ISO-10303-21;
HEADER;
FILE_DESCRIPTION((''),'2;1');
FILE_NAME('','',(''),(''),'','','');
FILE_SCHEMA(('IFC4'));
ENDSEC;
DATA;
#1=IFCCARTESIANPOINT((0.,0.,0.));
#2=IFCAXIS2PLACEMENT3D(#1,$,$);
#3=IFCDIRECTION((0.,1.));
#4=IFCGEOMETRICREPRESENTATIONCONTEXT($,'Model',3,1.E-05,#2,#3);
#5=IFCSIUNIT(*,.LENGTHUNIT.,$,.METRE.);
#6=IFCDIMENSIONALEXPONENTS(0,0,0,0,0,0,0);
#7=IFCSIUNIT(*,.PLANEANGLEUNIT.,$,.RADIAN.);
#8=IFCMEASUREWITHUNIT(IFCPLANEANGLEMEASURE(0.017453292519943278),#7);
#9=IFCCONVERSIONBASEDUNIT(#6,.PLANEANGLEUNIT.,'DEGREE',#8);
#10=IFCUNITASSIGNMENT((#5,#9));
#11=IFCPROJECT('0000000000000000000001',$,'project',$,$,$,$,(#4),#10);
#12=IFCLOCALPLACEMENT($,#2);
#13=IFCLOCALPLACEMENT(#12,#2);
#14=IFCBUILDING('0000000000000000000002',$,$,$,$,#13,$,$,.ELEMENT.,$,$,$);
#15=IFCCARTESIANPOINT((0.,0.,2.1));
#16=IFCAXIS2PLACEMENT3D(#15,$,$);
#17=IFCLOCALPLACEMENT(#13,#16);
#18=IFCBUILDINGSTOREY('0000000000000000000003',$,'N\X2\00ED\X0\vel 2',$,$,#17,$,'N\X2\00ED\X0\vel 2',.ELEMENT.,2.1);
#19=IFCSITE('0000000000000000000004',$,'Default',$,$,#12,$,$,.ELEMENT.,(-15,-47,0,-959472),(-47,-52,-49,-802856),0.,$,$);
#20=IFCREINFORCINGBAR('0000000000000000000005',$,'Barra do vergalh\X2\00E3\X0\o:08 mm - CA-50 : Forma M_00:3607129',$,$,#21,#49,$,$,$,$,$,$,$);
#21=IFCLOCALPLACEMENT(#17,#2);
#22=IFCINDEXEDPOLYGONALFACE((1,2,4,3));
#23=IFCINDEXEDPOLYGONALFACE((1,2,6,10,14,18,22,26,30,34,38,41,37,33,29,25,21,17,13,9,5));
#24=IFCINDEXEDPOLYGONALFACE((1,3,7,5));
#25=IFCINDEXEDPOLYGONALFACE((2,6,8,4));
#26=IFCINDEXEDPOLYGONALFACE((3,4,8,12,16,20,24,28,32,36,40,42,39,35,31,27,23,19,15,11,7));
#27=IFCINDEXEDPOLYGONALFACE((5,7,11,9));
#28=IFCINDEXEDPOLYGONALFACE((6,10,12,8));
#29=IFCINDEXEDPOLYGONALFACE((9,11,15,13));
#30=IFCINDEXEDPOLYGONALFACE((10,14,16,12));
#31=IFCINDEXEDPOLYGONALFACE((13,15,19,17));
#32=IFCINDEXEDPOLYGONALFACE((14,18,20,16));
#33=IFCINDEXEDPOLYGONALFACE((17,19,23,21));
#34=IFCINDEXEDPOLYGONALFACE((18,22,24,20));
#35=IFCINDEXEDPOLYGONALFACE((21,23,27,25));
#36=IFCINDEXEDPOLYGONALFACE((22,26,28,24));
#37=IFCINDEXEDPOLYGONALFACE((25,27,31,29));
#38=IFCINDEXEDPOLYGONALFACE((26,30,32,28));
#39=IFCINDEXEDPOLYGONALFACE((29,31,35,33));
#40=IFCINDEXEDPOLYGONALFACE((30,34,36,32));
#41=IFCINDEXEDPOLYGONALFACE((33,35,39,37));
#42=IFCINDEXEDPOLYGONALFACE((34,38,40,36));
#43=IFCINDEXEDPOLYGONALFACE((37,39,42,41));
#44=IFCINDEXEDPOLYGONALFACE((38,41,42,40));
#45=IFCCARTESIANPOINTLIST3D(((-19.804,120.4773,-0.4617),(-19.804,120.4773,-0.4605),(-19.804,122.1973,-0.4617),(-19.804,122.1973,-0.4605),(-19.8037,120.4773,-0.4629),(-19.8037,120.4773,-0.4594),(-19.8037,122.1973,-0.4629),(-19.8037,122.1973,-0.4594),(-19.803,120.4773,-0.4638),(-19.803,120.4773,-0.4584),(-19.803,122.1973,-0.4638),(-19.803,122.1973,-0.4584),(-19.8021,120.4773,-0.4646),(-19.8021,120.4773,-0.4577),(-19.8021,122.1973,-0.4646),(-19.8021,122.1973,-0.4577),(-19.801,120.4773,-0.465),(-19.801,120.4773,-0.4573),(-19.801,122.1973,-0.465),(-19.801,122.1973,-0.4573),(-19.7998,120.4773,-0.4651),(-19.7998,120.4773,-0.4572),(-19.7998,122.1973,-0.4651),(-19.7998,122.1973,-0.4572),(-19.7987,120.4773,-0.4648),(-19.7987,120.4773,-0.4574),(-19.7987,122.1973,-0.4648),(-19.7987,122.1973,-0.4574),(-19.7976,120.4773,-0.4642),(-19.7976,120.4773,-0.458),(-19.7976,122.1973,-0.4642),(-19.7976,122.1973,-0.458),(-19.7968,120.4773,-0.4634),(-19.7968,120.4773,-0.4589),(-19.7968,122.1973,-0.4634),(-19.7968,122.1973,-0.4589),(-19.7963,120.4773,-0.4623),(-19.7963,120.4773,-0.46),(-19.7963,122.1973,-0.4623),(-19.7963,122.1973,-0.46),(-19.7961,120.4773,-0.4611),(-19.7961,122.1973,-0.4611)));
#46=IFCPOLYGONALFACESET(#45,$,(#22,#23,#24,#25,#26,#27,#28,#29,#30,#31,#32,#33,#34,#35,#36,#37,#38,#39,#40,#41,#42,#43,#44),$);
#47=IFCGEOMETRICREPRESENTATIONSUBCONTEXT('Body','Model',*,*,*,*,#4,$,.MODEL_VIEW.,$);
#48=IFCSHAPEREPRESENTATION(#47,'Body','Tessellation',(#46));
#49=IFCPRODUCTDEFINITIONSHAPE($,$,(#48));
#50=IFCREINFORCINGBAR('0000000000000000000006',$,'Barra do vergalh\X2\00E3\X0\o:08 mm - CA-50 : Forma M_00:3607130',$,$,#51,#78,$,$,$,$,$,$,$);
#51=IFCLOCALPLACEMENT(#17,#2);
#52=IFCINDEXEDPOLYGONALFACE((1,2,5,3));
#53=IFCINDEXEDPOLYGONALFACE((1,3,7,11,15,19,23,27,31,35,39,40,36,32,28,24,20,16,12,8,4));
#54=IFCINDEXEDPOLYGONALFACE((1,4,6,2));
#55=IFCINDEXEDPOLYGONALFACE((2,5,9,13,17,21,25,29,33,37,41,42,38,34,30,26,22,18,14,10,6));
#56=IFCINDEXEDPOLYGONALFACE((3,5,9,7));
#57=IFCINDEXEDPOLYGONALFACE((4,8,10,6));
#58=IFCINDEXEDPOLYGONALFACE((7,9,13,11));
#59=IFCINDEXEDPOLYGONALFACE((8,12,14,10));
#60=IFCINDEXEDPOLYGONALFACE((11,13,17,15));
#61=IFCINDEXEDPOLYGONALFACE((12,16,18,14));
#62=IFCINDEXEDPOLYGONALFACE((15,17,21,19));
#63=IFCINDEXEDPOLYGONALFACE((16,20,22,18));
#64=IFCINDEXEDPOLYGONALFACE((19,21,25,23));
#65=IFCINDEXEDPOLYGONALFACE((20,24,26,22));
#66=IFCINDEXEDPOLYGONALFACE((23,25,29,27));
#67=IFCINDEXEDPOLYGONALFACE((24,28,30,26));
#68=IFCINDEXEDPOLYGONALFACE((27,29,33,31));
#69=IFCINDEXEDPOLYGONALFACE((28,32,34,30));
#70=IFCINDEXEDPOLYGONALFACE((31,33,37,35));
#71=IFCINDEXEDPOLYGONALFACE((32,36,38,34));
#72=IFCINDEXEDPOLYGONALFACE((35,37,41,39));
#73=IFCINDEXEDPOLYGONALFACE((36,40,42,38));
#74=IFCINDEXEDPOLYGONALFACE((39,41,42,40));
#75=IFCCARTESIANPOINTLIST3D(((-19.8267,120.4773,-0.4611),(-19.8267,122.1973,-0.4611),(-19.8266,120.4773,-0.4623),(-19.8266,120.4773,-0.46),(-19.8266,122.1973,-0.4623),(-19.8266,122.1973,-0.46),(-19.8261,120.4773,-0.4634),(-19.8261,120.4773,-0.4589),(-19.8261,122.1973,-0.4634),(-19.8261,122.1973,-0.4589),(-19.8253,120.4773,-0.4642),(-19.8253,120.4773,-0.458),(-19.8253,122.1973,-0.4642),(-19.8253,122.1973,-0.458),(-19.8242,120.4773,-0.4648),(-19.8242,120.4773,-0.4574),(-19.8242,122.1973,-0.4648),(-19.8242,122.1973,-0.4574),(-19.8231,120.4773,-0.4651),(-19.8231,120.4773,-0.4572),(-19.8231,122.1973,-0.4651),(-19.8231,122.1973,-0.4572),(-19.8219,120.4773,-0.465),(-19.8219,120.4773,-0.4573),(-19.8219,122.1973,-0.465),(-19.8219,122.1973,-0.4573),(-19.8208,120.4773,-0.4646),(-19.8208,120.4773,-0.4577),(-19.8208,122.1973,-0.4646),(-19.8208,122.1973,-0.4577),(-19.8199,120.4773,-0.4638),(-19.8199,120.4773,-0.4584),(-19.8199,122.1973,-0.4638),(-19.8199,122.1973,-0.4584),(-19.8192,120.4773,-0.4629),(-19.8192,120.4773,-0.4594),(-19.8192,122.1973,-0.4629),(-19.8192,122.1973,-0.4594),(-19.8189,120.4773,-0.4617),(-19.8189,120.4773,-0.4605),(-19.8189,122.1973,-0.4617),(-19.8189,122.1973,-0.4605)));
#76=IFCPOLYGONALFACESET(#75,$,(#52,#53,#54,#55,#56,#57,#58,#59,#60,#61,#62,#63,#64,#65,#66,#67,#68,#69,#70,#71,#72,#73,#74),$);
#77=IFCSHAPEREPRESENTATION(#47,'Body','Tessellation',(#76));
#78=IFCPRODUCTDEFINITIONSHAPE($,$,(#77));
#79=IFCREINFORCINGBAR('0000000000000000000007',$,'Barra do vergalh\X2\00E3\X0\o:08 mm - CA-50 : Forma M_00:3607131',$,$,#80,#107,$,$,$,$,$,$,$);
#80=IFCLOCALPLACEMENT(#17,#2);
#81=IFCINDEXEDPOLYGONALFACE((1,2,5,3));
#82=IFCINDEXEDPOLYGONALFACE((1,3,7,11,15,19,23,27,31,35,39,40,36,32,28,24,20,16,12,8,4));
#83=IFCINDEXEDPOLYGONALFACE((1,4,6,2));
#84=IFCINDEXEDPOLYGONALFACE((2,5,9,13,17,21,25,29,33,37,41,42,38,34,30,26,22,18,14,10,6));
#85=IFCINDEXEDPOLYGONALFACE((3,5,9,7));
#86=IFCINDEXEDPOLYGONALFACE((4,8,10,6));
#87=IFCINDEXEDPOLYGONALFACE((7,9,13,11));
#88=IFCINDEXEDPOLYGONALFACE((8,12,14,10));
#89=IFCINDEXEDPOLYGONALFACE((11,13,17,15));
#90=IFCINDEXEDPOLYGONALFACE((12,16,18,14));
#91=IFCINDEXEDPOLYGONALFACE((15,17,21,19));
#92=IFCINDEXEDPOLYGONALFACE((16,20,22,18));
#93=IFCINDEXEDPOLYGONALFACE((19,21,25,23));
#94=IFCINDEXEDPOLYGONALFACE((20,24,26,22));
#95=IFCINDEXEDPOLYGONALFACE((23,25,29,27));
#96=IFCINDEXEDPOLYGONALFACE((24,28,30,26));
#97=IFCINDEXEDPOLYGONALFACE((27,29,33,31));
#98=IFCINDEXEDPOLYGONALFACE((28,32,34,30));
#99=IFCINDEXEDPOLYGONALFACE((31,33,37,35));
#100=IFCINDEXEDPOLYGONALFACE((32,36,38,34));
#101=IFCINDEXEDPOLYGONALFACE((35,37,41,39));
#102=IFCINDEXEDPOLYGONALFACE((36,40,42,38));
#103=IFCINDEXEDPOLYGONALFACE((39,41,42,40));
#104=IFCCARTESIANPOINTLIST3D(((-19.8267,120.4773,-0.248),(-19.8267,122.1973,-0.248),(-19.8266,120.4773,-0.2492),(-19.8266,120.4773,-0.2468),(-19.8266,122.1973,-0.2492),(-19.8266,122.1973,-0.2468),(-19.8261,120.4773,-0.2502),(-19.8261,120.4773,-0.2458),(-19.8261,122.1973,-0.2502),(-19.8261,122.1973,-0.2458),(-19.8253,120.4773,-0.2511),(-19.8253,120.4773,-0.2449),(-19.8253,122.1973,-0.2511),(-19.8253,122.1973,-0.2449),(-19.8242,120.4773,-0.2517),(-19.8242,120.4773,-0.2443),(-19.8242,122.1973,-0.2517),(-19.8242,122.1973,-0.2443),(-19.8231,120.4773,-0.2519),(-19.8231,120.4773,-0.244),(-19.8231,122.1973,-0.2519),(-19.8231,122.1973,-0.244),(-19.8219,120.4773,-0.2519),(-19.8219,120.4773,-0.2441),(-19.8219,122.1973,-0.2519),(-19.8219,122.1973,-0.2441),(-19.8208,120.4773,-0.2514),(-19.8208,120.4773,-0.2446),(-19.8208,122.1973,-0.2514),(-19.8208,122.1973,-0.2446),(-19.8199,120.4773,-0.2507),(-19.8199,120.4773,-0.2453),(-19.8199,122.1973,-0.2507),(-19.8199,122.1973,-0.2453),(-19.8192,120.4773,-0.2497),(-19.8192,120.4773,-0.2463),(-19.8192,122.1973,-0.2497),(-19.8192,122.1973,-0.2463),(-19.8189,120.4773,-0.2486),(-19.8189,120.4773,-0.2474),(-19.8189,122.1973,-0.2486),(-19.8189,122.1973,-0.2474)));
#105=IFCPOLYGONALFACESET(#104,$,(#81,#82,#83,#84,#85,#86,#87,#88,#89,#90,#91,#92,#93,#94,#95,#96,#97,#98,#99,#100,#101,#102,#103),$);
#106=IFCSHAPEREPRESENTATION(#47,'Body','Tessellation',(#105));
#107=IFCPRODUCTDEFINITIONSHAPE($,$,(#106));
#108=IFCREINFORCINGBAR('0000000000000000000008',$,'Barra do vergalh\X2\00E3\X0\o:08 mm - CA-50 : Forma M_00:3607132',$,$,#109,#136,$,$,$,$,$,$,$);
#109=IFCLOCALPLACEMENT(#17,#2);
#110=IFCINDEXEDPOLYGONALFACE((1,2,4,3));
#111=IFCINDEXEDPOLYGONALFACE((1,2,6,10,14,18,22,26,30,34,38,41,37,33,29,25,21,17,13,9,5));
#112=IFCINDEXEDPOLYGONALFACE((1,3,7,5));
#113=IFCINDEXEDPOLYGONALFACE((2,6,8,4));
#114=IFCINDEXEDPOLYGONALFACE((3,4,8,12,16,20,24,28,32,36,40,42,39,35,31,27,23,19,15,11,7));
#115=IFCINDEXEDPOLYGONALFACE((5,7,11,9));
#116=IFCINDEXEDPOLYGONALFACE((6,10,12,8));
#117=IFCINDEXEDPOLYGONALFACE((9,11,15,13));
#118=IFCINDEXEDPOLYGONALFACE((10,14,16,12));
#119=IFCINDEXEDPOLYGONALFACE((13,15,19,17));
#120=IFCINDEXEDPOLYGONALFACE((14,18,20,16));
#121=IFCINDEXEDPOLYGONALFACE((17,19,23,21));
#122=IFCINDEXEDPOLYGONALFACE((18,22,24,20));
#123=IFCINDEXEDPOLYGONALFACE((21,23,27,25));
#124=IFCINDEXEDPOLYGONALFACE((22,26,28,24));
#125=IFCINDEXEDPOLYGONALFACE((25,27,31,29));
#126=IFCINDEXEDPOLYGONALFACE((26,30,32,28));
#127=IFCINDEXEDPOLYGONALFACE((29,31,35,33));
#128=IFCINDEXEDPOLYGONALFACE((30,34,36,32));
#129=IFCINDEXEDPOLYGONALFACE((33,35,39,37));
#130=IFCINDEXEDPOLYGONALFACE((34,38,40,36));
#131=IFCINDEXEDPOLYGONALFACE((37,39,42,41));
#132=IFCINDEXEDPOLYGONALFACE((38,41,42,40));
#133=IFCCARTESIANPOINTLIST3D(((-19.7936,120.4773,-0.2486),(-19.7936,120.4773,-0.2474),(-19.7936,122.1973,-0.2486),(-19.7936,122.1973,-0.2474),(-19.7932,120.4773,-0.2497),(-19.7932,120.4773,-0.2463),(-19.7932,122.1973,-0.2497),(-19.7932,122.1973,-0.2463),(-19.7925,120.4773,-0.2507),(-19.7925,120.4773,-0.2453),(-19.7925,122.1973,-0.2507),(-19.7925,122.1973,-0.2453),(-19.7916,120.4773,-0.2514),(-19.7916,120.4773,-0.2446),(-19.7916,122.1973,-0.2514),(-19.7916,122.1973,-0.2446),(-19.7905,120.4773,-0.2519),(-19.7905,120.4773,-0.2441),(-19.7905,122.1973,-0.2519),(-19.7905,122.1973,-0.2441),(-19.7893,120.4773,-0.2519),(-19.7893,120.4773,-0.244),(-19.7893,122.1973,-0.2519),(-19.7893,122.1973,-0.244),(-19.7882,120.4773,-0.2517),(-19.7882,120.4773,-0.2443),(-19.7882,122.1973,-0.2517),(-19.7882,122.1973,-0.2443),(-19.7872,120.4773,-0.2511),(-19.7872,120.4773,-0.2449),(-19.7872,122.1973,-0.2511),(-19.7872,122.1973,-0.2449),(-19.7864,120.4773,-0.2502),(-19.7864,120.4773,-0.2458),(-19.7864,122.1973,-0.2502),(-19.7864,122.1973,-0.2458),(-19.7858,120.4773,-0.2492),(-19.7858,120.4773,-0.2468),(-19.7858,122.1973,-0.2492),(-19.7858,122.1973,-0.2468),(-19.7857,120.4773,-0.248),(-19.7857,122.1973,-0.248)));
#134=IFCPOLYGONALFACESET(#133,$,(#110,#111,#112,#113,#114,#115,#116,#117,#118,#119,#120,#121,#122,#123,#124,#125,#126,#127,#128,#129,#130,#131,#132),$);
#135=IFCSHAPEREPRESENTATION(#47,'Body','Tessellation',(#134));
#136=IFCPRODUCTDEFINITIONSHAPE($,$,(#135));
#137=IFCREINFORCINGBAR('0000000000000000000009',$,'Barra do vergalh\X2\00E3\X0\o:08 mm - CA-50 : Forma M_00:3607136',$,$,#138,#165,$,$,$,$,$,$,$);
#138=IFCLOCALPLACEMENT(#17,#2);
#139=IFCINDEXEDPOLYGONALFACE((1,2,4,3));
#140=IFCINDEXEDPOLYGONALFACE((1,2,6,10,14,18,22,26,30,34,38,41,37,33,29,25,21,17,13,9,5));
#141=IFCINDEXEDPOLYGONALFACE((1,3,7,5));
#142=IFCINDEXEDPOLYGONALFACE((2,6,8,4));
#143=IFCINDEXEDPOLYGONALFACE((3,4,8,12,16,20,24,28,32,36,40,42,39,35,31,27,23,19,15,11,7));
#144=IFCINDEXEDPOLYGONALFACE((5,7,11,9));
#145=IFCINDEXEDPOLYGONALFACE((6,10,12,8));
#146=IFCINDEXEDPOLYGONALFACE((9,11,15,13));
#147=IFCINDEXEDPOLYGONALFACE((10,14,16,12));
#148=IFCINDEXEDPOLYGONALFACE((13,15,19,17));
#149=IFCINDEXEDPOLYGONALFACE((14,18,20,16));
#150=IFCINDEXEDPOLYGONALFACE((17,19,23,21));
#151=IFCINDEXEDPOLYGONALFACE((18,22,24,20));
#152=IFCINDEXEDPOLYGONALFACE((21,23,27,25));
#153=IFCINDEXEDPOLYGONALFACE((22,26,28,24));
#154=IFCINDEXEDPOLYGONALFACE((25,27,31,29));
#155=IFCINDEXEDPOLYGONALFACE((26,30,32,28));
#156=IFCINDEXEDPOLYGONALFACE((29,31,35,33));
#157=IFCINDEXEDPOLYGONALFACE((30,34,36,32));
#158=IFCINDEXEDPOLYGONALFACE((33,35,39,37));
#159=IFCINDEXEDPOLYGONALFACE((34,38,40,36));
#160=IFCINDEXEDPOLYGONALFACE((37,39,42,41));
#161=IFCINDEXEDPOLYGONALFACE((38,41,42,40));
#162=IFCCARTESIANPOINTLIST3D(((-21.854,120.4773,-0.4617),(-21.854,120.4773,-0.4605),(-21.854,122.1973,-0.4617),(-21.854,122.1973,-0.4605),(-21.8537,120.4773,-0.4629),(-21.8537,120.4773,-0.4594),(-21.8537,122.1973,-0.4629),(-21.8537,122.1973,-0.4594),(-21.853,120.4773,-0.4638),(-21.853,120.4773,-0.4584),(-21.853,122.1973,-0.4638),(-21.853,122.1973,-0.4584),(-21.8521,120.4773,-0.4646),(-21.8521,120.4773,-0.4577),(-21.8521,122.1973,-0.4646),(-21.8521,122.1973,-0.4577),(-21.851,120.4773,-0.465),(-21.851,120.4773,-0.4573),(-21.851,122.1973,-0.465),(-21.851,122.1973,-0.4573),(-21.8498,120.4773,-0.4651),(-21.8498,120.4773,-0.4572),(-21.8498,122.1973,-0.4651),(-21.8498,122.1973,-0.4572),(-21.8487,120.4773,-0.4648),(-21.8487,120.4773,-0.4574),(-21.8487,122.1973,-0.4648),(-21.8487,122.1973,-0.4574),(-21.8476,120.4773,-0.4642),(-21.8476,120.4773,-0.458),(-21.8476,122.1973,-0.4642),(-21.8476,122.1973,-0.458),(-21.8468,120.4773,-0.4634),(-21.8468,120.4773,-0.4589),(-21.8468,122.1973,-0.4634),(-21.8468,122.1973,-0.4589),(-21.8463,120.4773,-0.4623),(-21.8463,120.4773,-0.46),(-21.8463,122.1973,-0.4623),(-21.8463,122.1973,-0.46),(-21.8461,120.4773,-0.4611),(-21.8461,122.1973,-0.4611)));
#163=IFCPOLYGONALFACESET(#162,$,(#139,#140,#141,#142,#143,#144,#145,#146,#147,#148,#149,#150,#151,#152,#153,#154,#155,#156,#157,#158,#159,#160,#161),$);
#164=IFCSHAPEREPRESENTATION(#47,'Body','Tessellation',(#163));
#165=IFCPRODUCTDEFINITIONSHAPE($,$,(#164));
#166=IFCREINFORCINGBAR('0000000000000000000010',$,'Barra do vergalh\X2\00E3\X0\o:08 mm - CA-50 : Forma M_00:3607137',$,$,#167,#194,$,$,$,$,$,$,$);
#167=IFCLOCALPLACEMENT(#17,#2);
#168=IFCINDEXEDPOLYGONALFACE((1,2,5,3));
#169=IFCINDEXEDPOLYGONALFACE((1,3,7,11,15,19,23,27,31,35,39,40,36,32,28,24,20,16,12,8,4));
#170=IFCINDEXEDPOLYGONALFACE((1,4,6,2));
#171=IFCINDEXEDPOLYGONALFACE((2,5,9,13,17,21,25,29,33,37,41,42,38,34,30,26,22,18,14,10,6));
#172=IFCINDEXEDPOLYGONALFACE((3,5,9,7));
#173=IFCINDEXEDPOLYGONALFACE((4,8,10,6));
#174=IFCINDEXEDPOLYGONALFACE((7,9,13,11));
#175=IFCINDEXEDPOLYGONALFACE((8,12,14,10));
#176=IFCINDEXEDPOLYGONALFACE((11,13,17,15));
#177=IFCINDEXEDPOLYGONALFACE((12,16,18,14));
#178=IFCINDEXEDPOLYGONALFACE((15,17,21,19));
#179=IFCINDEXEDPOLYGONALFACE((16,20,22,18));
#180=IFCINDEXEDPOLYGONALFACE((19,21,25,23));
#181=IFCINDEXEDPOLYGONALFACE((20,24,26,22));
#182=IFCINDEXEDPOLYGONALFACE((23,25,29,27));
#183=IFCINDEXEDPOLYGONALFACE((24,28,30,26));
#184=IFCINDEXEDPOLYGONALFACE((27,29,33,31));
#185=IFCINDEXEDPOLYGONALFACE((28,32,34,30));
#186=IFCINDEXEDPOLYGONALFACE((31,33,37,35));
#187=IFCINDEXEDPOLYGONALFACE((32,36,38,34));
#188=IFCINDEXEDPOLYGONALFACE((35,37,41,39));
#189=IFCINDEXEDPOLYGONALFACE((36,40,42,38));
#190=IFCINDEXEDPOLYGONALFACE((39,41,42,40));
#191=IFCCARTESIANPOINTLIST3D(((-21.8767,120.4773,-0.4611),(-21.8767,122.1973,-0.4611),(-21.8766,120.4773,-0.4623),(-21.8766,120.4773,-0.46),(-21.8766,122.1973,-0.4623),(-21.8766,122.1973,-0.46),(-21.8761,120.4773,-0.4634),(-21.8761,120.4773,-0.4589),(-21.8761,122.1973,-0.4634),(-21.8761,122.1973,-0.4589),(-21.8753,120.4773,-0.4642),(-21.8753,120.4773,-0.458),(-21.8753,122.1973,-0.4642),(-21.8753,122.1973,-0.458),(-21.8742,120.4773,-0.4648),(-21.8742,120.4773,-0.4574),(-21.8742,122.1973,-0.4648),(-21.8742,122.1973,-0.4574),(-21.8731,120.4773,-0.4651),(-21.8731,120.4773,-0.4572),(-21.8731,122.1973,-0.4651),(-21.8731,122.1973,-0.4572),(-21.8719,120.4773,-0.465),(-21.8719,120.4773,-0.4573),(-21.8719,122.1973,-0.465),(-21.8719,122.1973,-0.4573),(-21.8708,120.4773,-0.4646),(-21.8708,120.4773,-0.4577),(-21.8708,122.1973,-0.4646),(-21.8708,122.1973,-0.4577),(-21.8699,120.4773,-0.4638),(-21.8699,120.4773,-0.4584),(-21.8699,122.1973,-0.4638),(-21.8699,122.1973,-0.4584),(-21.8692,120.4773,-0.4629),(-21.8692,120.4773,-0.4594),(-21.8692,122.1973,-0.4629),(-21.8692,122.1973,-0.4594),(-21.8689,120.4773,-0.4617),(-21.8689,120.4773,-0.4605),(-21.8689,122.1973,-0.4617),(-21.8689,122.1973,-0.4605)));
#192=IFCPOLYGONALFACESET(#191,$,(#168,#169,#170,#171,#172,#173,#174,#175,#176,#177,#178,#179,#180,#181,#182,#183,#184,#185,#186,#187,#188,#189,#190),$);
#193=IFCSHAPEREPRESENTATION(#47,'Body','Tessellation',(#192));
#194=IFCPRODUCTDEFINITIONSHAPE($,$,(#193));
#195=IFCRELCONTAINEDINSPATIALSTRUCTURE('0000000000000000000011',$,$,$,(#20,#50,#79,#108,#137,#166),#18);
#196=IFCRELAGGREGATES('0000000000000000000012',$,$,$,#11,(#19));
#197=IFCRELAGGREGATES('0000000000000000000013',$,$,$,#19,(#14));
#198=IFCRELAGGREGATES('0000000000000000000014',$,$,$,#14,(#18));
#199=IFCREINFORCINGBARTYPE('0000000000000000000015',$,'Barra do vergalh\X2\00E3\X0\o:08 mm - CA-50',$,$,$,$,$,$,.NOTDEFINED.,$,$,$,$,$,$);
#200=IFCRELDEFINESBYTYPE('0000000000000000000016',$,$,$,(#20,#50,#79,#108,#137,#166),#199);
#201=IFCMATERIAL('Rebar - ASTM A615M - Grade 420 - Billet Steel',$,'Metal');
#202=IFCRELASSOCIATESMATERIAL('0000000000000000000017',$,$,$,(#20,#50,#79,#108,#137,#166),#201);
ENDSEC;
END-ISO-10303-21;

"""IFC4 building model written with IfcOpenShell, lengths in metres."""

from ifc_helpers import new_model, entity, si_unit, converted_unit, direction, frame, origin, place, context, subcontext, project, spatial, material, type_object, element, save


model = new_model("IFC4")

# Units and contexts
model_context = context("Model", 3, precision=1e-05, world=origin(), true_north=direction((0.0, 1.0)))
body_context = subcontext(model_context, "Body", "Model", "MODEL_VIEW")
ifc_project = project(units=[si_unit("LENGTHUNIT", "METRE"), converted_unit("PLANEANGLEUNIT", "DEGREE", entity("IfcPlaneAngleMeasure", 0.017453292519943278), si_unit("PLANEANGLEUNIT", "RADIAN"), dimensions=[0, 0, 0, 0, 0, 0, 0])], contexts=[model_context])

# Site, building, storey
site_placement = place(None, origin())
site = spatial("IfcSite", under=ifc_project, at=site_placement, Name="Default", CompositionType="ELEMENT", RefLatitude=(-15, -47, 0, -959472), RefLongitude=(-47, -52, -49, -802856), RefElevation=0.0)
building_placement = place(site_placement, origin())
building = spatial("IfcBuilding", under=site, at=building_placement, CompositionType="ELEMENT")
storey_placement = place(building_placement, frame((0.0, 0.0, 2.1)))
storey = spatial("IfcBuildingStorey", under=building, at=storey_placement, Name="Nível 2", LongName="Nível 2", CompositionType="ELEMENT", Elevation=2.1)

# Reinforcing bars
ifc_material = material(Name="Rebar - ASTM A615M - Grade 420 - Billet Steel", Category="Metal")
reinforcing_bar_type_1 = type_object("IfcReinforcingBarType", Name="Barra do vergalhão:08 mm - CA-50", PredefinedType="NOTDEFINED")
reinforcing_bar_1_placement = place(storey_placement, origin())
element("IfcReinforcingBar", 1, at=reinforcing_bar_1_placement, inside=storey, type_object=reinforcing_bar_type_1, material=ifc_material, Name="Barra do vergalhão:08 mm - CA-50 : Forma M_00:3607129", context=body_context, shape_type="AdvancedSweptSolid", body=[
    entity("IfcSweptDiskSolid", entity("IfcIndexedPolyCurve", entity("IfcCartesianPointList3D", [[19.8001, -122.1973, 0.4611], [19.8001, -120.4773, 0.4611]]), None, False), 0.004, None, 0.0, 1.0),
])
reinforcing_bar_2_placement = place(storey_placement, origin())
element("IfcReinforcingBar", 2, at=reinforcing_bar_2_placement, inside=storey, type_object=reinforcing_bar_type_1, material=ifc_material, Name="Barra do vergalhão:08 mm - CA-50 : Forma M_00:3607130", context=body_context, shape_type="AdvancedSweptSolid", body=[
    entity("IfcSweptDiskSolid", entity("IfcIndexedPolyCurve", entity("IfcCartesianPointList3D", [[19.8228, -120.4773, 0.4611], [19.8228, -122.1973, 0.4611]]), None, False), 0.004, None, 0.0, 1.0),
])
reinforcing_bar_3_placement = place(storey_placement, origin())
element("IfcReinforcingBar", 3, at=reinforcing_bar_3_placement, inside=storey, type_object=reinforcing_bar_type_1, material=ifc_material, Name="Barra do vergalhão:08 mm - CA-50 : Forma M_00:3607131", context=body_context, shape_type="AdvancedSweptSolid", body=[
    entity("IfcSweptDiskSolid", entity("IfcIndexedPolyCurve", entity("IfcCartesianPointList3D", [[19.8228, -120.4773, 0.248], [19.8228, -122.1973, 0.248]]), None, False), 0.004, None, 0.0, 1.0),
])
reinforcing_bar_4_placement = place(storey_placement, origin())
element("IfcReinforcingBar", 4, at=reinforcing_bar_4_placement, inside=storey, type_object=reinforcing_bar_type_1, material=ifc_material, Name="Barra do vergalhão:08 mm - CA-50 : Forma M_00:3607132", context=body_context, shape_type="AdvancedSweptSolid", body=[
    entity("IfcSweptDiskSolid", entity("IfcIndexedPolyCurve", entity("IfcCartesianPointList3D", [[19.7896, -122.1973, 0.248], [19.7896, -120.4773, 0.248]]), None, False), 0.004, None, 0.0, 1.0),
])
reinforcing_bar_5_placement = place(storey_placement, origin())
element("IfcReinforcingBar", 5, at=reinforcing_bar_5_placement, inside=storey, type_object=reinforcing_bar_type_1, material=ifc_material, Name="Barra do vergalhão:08 mm - CA-50 : Forma M_00:3607136", context=body_context, shape_type="AdvancedSweptSolid", body=[
    entity("IfcSweptDiskSolid", entity("IfcIndexedPolyCurve", entity("IfcCartesianPointList3D", [[21.8501, -122.1973, 0.4611], [21.8501, -120.4773, 0.4611]]), None, False), 0.004, None, 0.0, 1.0),
])
reinforcing_bar_6_placement = place(storey_placement, origin())
element("IfcReinforcingBar", 6, at=reinforcing_bar_6_placement, inside=storey, type_object=reinforcing_bar_type_1, material=ifc_material, Name="Barra do vergalhão:08 mm - CA-50 : Forma M_00:3607137", context=body_context, shape_type="AdvancedSweptSolid", body=[
    entity("IfcSweptDiskSolid", entity("IfcIndexedPolyCurve", entity("IfcCartesianPointList3D", [[21.8728, -120.4773, 0.4611], [21.8728, -122.1973, 0.4611]]), None, False), 0.004, None, 0.0, 1.0),
])

save(model, "model.ifc")
